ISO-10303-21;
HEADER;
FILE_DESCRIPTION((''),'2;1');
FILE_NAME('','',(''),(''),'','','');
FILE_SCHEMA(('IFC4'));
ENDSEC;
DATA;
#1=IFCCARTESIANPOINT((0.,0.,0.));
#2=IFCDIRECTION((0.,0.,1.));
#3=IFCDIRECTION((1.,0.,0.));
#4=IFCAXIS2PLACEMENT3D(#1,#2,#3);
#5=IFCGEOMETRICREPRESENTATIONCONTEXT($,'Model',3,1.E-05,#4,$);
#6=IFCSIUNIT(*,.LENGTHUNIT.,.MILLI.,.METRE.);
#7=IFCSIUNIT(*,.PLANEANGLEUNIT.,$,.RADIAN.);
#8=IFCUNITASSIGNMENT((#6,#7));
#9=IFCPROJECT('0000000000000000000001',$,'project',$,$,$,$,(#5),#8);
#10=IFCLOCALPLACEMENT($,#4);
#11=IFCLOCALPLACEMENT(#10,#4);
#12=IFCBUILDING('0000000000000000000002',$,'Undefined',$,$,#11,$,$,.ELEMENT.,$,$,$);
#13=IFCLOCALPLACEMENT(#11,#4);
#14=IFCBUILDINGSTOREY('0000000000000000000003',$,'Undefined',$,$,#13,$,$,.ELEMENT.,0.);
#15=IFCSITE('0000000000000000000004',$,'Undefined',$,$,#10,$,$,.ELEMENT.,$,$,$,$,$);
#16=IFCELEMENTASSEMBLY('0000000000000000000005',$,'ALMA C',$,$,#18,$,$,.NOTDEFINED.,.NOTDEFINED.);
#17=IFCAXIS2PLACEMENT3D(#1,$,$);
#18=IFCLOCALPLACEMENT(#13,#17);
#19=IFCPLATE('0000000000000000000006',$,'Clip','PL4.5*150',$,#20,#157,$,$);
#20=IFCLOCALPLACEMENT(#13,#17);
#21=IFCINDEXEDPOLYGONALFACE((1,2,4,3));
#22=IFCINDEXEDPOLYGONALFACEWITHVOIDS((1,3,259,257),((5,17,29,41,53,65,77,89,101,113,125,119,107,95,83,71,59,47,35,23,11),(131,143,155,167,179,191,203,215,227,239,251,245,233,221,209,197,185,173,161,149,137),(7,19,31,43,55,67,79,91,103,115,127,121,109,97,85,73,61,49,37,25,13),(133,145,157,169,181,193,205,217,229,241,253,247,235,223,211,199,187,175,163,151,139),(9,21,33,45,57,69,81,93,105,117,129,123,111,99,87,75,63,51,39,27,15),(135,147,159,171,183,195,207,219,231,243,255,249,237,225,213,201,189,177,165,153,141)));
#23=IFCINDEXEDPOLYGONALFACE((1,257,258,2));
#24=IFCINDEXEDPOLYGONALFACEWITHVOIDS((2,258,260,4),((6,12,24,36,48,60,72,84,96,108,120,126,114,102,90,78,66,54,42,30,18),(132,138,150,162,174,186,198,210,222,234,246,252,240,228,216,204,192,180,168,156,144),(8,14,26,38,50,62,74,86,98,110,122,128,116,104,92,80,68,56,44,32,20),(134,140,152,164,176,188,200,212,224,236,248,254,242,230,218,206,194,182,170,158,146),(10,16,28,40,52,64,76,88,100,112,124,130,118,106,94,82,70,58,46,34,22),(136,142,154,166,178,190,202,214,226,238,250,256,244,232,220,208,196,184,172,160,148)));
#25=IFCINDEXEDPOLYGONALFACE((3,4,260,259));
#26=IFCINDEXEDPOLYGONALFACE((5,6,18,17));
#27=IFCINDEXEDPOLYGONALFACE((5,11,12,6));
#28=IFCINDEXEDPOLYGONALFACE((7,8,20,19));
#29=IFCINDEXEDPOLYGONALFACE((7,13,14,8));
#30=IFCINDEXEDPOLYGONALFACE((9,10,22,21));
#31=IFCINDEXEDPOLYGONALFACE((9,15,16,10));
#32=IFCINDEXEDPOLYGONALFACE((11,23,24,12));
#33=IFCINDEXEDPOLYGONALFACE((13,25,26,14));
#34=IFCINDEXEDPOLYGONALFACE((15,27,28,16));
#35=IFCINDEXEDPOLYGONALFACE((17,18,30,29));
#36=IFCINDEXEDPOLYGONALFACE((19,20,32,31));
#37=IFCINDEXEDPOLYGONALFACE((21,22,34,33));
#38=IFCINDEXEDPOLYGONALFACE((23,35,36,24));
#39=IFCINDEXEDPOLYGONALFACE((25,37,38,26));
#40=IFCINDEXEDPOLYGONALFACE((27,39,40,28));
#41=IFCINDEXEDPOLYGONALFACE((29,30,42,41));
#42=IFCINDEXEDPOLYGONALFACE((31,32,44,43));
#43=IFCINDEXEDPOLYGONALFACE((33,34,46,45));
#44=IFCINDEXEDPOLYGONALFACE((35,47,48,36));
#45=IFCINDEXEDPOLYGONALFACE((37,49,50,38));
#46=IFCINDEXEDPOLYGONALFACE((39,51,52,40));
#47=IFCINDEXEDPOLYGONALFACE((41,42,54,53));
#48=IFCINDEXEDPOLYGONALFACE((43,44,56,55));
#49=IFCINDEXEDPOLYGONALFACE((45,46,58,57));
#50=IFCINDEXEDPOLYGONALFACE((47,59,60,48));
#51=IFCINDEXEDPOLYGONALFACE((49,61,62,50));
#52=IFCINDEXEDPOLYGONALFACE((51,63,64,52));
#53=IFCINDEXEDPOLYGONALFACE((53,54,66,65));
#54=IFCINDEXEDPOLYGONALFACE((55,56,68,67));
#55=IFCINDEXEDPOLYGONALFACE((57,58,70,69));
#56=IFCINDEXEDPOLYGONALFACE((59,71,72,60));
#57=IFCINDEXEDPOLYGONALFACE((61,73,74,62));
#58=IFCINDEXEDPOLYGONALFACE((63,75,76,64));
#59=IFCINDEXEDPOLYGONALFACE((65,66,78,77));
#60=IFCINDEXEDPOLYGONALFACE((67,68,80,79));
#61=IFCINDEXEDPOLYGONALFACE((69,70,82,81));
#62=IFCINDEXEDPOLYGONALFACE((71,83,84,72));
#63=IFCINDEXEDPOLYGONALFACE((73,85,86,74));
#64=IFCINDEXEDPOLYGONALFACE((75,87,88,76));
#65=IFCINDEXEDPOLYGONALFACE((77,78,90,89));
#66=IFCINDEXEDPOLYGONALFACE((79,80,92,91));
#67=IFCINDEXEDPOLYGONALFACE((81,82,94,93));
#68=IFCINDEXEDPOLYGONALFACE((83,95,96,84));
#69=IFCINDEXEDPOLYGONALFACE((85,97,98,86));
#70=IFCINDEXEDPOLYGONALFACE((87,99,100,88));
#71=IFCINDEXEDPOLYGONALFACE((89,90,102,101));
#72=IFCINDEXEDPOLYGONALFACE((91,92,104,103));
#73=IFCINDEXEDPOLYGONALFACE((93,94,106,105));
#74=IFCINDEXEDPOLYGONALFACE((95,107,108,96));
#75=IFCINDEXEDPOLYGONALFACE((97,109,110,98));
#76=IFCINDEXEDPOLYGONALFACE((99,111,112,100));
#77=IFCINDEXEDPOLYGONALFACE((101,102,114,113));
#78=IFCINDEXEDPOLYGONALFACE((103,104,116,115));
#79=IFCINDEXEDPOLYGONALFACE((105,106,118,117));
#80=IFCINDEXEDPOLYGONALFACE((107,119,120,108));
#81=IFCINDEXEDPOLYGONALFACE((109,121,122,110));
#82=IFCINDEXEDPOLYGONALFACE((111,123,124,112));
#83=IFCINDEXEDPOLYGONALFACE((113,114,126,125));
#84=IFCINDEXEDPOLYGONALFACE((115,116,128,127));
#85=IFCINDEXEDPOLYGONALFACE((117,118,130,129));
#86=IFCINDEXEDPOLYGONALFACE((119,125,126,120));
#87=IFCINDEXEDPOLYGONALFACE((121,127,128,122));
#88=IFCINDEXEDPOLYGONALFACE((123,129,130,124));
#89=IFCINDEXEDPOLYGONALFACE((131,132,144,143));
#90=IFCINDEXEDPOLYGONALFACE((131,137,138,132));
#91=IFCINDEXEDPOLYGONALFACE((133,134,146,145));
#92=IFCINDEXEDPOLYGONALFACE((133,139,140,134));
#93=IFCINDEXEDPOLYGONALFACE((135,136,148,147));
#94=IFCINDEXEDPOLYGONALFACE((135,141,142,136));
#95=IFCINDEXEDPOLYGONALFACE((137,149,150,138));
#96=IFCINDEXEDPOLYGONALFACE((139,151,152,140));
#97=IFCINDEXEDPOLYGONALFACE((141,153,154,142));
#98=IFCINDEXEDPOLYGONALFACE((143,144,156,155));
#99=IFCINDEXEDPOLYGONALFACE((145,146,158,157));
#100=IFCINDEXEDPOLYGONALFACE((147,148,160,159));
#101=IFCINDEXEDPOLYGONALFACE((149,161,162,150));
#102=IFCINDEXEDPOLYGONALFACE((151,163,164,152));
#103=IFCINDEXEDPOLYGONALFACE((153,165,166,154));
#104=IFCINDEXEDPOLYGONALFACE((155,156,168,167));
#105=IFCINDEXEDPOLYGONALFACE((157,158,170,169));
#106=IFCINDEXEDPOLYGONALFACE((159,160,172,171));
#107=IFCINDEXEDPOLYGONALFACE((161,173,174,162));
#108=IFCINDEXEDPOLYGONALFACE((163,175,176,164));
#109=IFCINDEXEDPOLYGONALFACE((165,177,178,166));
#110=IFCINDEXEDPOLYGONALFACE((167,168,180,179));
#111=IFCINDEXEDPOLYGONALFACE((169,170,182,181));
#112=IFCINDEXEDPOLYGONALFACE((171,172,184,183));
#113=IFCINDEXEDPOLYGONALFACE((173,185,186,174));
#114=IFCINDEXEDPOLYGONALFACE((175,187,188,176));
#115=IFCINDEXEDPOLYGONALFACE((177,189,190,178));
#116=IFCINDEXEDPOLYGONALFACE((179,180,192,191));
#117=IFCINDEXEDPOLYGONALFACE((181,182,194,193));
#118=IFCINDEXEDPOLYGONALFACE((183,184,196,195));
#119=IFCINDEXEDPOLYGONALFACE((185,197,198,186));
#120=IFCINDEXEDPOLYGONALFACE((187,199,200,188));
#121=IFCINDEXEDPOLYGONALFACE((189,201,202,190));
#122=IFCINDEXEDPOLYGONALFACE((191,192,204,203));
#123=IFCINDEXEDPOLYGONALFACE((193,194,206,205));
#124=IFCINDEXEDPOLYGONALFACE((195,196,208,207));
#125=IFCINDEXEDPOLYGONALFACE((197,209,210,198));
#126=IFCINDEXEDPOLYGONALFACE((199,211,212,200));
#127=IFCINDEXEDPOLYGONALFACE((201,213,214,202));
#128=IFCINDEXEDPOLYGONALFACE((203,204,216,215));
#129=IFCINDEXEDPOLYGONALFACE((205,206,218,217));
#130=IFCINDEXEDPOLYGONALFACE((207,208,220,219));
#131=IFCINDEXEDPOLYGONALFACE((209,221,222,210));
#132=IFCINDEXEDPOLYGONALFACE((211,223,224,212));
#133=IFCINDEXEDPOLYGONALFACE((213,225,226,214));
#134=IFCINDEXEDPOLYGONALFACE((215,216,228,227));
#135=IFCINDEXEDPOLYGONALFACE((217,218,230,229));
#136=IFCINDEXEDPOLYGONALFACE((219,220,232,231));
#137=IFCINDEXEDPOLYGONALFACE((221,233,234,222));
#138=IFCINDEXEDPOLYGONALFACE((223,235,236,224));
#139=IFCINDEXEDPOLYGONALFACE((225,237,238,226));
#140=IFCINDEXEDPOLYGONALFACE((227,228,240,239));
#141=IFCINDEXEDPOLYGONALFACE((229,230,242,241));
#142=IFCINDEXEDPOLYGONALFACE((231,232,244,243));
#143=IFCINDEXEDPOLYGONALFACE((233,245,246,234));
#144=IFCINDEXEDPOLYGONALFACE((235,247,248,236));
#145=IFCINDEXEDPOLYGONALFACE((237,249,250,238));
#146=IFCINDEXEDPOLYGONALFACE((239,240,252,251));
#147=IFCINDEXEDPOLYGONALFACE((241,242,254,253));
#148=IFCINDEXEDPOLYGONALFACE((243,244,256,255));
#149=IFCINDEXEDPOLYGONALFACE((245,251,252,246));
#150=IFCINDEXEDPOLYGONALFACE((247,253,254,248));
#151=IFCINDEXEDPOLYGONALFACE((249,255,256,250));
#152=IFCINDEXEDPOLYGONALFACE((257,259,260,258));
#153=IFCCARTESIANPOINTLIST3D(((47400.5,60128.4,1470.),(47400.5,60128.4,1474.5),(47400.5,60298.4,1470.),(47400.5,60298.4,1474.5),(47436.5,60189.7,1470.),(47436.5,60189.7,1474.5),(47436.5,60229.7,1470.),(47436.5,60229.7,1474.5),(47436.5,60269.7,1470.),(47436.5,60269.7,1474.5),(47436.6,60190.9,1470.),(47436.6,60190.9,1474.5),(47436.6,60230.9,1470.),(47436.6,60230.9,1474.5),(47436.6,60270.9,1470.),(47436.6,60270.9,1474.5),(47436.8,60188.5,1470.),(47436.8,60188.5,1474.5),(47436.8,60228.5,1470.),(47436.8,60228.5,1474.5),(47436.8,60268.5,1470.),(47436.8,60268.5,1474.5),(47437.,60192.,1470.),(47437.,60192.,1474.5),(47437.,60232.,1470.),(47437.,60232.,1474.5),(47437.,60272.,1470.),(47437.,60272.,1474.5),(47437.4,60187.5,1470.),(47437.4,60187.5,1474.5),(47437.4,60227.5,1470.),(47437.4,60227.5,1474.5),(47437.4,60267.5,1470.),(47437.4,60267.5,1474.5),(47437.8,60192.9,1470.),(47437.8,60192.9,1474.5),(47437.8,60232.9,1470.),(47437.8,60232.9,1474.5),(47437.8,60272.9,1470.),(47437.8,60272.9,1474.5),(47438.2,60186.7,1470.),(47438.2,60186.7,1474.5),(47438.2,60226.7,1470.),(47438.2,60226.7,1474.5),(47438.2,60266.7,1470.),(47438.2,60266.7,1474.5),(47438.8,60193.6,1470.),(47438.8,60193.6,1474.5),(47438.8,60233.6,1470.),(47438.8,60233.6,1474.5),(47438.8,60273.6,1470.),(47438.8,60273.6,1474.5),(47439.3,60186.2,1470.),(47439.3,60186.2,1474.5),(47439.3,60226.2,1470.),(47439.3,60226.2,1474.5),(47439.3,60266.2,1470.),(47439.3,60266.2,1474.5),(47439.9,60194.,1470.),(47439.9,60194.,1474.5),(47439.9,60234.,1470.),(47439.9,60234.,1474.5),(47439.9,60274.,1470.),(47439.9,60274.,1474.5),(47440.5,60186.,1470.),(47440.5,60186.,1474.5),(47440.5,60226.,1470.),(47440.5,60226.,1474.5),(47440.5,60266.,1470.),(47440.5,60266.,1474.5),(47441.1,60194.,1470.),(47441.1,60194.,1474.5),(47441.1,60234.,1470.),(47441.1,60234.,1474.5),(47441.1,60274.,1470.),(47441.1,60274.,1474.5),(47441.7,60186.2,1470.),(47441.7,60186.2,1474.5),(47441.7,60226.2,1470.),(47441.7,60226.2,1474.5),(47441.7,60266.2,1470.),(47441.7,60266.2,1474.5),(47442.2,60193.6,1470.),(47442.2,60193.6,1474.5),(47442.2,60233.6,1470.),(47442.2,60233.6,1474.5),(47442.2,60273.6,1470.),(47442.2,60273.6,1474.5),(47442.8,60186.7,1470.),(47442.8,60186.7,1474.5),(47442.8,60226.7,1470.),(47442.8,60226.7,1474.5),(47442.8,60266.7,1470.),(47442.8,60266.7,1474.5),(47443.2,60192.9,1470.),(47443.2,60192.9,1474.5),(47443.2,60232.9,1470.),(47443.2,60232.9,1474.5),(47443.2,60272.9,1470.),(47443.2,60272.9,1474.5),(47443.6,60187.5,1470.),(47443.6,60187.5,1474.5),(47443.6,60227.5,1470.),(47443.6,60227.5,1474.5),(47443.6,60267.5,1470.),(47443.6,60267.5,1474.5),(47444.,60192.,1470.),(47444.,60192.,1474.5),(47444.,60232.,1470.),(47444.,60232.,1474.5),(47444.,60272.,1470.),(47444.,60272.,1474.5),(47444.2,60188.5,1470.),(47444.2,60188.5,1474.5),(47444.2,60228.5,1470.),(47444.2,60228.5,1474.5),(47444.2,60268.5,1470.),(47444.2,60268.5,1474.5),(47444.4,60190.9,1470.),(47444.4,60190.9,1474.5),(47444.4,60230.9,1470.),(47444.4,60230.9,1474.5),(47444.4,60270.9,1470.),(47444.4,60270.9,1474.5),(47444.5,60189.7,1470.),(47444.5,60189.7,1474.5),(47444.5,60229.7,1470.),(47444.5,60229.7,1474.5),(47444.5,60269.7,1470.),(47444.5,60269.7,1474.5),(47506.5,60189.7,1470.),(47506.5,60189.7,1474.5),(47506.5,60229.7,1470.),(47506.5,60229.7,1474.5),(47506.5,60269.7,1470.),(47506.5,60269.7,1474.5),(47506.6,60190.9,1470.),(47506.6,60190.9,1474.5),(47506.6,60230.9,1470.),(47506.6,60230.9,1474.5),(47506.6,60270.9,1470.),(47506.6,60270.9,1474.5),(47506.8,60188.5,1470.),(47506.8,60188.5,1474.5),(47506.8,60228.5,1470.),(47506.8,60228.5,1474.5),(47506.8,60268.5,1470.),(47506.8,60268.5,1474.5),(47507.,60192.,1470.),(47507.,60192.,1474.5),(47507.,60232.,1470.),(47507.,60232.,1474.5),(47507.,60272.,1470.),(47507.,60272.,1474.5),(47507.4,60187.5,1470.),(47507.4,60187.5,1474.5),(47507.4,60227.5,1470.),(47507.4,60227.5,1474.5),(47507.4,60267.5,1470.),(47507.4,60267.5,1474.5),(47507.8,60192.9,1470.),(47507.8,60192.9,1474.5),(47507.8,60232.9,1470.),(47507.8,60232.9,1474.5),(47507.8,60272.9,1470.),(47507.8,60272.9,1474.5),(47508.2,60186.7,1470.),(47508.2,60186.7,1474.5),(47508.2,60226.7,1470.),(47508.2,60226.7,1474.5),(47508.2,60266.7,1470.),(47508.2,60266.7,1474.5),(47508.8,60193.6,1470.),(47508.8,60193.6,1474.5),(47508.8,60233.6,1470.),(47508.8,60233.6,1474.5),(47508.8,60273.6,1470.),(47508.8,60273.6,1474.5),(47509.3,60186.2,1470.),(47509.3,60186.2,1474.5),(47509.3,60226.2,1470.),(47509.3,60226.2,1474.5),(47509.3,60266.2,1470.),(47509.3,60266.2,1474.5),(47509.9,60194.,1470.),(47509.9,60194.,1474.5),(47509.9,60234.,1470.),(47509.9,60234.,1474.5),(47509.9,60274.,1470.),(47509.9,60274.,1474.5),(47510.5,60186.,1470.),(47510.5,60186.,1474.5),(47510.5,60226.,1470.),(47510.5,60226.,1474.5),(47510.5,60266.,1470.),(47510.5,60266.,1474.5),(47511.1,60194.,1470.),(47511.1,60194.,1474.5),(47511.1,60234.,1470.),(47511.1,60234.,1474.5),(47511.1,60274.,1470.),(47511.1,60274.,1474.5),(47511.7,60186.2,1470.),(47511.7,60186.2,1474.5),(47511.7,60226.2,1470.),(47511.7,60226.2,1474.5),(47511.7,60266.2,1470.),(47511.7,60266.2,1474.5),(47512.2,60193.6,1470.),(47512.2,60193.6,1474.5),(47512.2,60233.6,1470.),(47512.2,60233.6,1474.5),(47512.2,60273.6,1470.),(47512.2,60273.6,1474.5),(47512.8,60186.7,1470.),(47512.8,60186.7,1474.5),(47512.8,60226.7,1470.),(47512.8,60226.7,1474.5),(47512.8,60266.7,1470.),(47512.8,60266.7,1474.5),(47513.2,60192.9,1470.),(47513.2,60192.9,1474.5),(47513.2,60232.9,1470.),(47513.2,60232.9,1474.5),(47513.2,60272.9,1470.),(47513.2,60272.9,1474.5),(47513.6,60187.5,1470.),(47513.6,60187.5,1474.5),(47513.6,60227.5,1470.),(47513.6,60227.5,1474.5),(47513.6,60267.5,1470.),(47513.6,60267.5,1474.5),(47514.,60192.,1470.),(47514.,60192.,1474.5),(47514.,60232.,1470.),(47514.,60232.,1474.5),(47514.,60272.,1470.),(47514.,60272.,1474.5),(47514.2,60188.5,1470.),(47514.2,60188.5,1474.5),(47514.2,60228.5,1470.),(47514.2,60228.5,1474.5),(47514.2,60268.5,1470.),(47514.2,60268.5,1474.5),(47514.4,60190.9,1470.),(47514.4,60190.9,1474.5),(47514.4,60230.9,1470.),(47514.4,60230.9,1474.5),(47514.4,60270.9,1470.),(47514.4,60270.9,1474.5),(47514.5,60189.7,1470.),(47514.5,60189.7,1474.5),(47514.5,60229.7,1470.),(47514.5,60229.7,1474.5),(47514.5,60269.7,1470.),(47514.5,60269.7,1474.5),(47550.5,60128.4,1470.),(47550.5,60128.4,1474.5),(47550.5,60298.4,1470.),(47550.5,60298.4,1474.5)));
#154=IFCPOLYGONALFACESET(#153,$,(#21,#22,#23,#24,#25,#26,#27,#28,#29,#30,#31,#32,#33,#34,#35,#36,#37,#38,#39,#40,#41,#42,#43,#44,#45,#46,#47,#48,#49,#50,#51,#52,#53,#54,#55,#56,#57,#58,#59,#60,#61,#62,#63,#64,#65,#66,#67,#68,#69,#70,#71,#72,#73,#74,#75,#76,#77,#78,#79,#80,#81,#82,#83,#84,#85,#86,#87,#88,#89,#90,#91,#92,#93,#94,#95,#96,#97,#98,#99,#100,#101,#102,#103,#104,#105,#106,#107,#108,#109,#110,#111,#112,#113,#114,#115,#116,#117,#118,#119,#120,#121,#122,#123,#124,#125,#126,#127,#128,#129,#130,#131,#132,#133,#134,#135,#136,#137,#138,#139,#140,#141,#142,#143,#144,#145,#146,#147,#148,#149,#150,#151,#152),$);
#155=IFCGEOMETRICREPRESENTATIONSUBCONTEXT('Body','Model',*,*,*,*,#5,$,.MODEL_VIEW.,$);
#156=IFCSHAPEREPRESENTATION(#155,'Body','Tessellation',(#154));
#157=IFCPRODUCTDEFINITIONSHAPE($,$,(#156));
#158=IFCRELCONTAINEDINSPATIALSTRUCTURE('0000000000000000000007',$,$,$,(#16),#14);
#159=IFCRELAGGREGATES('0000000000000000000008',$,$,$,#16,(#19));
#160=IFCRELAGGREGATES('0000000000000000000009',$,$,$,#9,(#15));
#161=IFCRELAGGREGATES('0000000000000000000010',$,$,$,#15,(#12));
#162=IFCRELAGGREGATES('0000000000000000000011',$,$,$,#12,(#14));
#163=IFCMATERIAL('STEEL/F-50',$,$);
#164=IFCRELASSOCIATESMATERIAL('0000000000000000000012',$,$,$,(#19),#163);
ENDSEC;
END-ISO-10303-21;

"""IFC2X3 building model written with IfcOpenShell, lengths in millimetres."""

from ifc_helpers import new_model, si_unit, frame, origin_with_axes, origin_2d_with_axis, place, context, subcontext, project, spatial, polyline, circle, outline, extrude, source, transform, mapped, material, element, aggregate, save


model = new_model("IFC2X3")

# Units and contexts
model_context = context("Model", 3, precision=1e-05, world=origin_with_axes())
body_context = subcontext(model_context, "Body", "Model", "MODEL_VIEW")
ifc_project = project(units=[si_unit("LENGTHUNIT", "METRE", prefix="MILLI"), si_unit("PLANEANGLEUNIT", "RADIAN")], contexts=[model_context])

# Site, building, storey
site_placement = place(None, origin_with_axes())
site = spatial("IfcSite", under=ifc_project, at=site_placement, Name="Undefined", CompositionType="ELEMENT")
building_placement = place(site_placement, origin_with_axes())
building = spatial("IfcBuilding", under=site, at=building_placement, Name="Undefined", CompositionType="ELEMENT")
storey_placement = place(building_placement, origin_with_axes())
storey = spatial("IfcBuildingStorey", under=building, at=storey_placement, Name="Undefined", CompositionType="ELEMENT", Elevation=0.0)

# Element assembly
assembly_1_placement = place(storey_placement, origin_with_axes())
assembly_1 = element("IfcElementAssembly", 1, at=assembly_1_placement, inside=storey, Name="ALMA C", AssemblyPlace="NOTDEFINED", PredefinedType="NOTDEFINED")

# Shared definitions
ifc_material_1 = material(Name="STEEL/F-50")

# Plate, openings
plate_1_placement = place(assembly_1_placement, frame((47400.5, 60128.4, 1472.2), z_axis=(0.0, 0.0, -1.0), x_axis=(0.0, 1.0, 0.0)))
plate_1 = element("IfcPlate", 2, at=plate_1_placement, material=ifc_material_1, Name="Clip", Description="PL4.5*150", context=body_context, shape_type="SweptSolid", body=[
    extrude(outline(polyline([(0.0, 0.0), (170.0, 0.0), (170.0, 150.0), (0.0, 150.0), (0.0, 0.0)])), frame((0.0, 0.0, -2.2), z_axis=(0.0, 0.0, 1.0), x_axis=(1.0, 0.0, 0.0)), (0.0, 0.0, 1.0), 4.5),
])
shared_shape_1 = source(origin_with_axes(), body_context, "Body", "SweptSolid", [
    extrude(circle(Radius=4.0, at=origin_2d_with_axis()), frame((0.0, -4.6, 0.0), z_axis=(0.0, 1.0, 0.0), x_axis=(1.0, 0.0, 0.0)), (0.0, 0.0, 1.0), 4.7),
])
opening_1_placement = place(assembly_1_placement, frame((47510.5, 60270.0, 1470.0), z_axis=(1.0, 0.0, 0.0), x_axis=(0.0, -1.0, 0.0)))
element("IfcOpeningElement", 3, at=opening_1_placement, cuts=plate_1, ObjectType="Opening", context=body_context, shape_type="MappedRepresentation", body=[
    mapped(shared_shape_1, transform((0.0, 0.0, 0.0))),
    mapped(shared_shape_1, transform((40.0, 0.0, 0.0))),
    mapped(shared_shape_1, transform((80.0, 0.0, 0.0))),
])
opening_2_placement = place(assembly_1_placement, frame((47440.5, 60270.0, 1470.0), z_axis=(1.0, 0.0, 0.0), x_axis=(0.0, -1.0, 0.0)))
element("IfcOpeningElement", 4, at=opening_2_placement, cuts=plate_1, ObjectType="Opening", context=body_context, shape_type="MappedRepresentation", body=[
    mapped(shared_shape_1, transform((0.0, 0.0, 0.0))),
    mapped(shared_shape_1, transform((40.0, 0.0, 0.0))),
    mapped(shared_shape_1, transform((80.0, 0.0, 0.0))),
])
aggregate(assembly_1, [plate_1])

save(model, "model.ifc")
